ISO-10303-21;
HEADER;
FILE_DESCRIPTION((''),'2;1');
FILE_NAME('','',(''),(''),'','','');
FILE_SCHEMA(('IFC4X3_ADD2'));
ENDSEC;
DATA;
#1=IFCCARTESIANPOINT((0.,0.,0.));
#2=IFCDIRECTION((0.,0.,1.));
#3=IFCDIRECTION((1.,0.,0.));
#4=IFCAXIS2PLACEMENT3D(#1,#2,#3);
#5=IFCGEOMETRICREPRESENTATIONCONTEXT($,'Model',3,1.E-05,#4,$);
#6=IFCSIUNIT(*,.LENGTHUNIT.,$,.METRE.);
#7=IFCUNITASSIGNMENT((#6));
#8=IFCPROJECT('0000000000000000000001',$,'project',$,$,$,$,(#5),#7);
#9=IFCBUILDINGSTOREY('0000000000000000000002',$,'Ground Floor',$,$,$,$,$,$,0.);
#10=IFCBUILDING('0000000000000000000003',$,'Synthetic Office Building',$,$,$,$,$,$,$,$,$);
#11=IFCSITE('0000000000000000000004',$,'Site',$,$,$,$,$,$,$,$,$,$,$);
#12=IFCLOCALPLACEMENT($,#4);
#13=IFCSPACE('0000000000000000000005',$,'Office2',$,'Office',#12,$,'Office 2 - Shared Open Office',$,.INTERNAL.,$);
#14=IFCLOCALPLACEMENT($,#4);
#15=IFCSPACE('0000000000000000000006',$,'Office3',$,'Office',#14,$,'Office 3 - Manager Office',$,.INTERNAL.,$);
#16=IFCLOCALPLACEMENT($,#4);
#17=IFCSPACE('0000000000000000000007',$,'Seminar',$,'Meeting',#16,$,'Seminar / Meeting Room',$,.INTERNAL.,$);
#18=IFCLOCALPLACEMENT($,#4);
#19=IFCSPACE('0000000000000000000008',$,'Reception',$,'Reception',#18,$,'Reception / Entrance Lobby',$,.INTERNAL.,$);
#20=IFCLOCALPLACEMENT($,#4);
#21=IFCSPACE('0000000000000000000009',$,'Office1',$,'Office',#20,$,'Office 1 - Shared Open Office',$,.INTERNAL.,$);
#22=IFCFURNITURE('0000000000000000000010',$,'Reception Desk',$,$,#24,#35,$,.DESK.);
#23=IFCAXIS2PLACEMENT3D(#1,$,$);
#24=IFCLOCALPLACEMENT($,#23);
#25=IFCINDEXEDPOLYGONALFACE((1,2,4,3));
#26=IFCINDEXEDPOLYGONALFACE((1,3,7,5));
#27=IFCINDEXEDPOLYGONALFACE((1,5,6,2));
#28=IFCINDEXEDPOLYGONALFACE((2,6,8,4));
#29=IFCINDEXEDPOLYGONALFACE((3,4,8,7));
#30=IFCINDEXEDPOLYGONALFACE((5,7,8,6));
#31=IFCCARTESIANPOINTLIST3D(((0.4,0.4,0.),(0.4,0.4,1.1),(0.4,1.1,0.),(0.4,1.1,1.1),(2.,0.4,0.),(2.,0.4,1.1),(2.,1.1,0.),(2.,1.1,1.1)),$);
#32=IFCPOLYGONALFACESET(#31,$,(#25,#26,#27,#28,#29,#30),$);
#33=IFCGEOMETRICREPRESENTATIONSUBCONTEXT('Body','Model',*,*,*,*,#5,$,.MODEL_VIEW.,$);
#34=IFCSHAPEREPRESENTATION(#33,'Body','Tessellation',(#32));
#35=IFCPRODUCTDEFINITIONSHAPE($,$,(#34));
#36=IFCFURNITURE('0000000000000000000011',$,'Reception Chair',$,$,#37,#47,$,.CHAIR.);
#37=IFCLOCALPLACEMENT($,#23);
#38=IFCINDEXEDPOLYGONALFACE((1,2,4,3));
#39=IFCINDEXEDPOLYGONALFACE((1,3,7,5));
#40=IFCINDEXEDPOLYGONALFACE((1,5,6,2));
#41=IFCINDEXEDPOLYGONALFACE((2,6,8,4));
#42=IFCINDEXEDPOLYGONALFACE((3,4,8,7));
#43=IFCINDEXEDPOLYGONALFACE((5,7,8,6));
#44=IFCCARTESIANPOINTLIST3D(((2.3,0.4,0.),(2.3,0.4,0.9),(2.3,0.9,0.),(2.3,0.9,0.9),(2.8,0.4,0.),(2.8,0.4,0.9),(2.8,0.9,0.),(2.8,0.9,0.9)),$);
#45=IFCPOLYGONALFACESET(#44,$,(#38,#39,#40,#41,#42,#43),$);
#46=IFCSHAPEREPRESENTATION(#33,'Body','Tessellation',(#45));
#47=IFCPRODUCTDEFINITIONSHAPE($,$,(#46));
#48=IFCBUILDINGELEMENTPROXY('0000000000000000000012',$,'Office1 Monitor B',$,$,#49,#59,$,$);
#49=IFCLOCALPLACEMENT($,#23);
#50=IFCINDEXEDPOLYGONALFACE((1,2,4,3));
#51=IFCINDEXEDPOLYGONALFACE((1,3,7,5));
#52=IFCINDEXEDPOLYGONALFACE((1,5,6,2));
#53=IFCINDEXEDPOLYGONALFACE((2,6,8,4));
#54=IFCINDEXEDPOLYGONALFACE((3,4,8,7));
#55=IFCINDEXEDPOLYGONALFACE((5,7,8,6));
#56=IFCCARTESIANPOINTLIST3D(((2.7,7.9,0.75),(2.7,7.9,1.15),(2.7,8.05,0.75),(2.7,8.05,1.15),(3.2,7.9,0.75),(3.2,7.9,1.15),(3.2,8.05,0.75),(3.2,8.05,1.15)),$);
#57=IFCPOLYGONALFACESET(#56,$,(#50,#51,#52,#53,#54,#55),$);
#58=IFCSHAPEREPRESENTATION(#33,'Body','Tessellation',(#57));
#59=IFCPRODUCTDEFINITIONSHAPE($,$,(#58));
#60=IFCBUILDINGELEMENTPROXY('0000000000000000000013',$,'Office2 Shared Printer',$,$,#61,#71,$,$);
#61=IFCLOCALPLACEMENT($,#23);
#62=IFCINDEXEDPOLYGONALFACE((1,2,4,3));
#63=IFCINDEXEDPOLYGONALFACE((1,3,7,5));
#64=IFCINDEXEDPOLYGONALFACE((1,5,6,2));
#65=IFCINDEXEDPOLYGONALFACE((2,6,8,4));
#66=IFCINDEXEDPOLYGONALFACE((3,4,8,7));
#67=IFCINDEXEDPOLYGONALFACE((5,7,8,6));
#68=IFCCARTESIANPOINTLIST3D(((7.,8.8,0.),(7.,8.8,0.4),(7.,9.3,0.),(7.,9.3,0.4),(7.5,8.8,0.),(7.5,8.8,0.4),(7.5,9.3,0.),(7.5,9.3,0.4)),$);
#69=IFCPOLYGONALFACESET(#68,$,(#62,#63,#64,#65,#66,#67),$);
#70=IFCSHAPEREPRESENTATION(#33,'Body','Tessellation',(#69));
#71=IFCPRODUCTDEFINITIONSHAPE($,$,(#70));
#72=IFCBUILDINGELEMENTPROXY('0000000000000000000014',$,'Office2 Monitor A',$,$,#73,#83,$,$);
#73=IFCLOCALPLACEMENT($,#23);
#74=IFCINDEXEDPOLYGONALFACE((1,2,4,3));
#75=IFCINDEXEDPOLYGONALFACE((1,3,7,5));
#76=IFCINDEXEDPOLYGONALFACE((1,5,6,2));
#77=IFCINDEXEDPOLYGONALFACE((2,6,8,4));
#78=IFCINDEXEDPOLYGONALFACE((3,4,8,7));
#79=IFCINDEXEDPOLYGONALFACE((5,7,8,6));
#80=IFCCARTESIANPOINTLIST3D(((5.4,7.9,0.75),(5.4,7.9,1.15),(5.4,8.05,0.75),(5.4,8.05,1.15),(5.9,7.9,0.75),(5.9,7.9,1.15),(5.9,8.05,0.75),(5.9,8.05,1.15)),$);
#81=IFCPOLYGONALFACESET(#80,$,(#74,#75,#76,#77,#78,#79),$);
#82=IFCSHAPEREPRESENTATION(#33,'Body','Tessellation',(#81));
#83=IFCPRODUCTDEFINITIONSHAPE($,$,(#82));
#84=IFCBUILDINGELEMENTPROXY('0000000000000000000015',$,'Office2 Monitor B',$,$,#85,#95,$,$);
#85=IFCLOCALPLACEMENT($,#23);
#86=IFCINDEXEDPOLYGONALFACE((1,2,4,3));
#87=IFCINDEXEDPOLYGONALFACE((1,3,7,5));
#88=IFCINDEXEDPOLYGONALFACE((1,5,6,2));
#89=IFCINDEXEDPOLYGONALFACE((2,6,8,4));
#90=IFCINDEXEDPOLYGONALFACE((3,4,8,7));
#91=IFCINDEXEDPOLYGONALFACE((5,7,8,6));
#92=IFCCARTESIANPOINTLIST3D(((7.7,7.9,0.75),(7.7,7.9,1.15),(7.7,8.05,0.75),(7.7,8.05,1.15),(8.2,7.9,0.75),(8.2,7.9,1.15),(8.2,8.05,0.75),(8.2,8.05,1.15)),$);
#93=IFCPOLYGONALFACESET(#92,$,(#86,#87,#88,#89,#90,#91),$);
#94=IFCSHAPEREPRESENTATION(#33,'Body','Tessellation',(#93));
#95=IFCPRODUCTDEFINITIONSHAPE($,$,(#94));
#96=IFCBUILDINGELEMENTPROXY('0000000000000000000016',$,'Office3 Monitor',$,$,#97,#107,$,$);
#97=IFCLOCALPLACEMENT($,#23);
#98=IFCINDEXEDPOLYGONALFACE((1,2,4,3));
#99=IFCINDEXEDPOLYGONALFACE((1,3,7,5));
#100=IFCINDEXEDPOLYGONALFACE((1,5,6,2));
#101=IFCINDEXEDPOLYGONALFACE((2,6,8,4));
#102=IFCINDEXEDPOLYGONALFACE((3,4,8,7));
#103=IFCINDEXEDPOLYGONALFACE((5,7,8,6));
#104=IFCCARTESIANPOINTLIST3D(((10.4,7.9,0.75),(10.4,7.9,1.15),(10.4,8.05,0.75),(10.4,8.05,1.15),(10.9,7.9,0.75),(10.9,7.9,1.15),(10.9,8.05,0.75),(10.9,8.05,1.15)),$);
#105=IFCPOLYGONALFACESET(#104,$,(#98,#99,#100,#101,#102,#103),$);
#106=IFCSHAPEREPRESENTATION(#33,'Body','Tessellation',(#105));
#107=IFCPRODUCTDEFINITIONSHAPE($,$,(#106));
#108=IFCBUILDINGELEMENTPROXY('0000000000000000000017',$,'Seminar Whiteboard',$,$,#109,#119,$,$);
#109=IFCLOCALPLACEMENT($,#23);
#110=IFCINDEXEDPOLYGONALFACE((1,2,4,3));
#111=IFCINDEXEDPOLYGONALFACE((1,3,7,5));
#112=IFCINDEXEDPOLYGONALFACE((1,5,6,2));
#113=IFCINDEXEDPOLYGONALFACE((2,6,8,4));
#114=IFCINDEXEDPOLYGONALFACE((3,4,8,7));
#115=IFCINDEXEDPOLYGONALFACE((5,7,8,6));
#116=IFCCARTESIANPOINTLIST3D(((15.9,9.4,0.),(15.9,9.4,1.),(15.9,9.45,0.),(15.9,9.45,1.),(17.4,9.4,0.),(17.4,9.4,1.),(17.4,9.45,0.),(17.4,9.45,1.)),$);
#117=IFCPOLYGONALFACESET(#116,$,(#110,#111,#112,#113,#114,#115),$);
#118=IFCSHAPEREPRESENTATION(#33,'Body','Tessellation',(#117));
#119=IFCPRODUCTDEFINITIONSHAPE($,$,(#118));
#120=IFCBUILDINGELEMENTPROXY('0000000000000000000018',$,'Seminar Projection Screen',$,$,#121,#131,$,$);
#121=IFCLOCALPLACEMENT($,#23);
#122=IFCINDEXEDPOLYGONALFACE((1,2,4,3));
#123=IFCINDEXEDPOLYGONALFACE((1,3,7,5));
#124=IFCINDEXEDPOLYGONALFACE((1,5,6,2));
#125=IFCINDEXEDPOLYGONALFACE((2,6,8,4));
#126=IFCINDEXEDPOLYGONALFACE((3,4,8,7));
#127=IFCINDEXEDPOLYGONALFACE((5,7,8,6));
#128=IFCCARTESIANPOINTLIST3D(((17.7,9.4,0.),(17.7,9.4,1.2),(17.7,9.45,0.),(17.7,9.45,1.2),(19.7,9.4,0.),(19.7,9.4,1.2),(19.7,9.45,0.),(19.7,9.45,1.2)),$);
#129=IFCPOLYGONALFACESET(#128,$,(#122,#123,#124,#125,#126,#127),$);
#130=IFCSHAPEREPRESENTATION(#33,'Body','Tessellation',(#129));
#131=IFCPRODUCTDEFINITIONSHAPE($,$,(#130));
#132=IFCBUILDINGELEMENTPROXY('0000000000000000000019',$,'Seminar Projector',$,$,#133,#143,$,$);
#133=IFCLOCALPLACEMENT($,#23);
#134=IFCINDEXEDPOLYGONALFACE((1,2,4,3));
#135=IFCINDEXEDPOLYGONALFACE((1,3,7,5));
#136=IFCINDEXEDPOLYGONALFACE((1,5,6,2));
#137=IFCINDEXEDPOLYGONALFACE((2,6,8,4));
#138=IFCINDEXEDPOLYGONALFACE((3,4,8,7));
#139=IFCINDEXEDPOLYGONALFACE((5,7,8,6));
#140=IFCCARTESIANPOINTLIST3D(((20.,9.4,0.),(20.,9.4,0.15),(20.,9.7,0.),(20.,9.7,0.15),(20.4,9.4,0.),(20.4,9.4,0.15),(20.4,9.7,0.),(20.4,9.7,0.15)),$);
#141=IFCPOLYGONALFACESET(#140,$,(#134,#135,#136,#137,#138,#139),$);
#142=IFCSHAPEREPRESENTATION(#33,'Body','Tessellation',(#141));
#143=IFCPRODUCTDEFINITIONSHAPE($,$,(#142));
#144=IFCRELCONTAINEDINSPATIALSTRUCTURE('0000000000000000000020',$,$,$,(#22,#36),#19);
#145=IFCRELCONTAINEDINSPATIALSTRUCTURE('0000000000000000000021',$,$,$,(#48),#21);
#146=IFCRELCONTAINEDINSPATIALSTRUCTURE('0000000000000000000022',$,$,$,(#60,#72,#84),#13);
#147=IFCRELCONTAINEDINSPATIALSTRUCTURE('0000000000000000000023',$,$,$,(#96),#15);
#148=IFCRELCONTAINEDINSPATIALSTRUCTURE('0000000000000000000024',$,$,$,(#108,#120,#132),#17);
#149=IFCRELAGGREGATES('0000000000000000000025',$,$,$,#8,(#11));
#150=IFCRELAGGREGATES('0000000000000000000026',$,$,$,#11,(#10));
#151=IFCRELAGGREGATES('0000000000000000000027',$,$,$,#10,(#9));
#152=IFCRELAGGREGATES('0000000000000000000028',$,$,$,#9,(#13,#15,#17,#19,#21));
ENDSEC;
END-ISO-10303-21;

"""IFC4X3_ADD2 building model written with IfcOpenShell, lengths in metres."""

from ifc_helpers import new_model, si_unit, frame, origin_with_axes, place, context, subcontext, project, spatial, polyline, outline, extrude, element, save


model = new_model("IFC4X3_ADD2")

# Units and contexts
model_context = context("Model", 3, precision=1e-05, world=origin_with_axes())
body_context = subcontext(model_context, "Body", "Model", "MODEL_VIEW")
ifc_project = project(units=[si_unit("LENGTHUNIT", "METRE")], contexts=[model_context])

# Site, building, storey, space
site = spatial("IfcSite", under=ifc_project, Name="Site")
building = spatial("IfcBuilding", under=site, Name="Synthetic Office Building")
storey = spatial("IfcBuildingStorey", under=building, Name="Ground Floor", Elevation=0.0)
space_1_placement = place(None, origin_with_axes())
space_1 = spatial("IfcSpace", under=storey, at=space_1_placement, Name="Office2", ObjectType="Office", LongName="Office 2 - Shared Open Office", PredefinedType="INTERNAL")

# Shared definitions
space_2_placement = place(None, origin_with_axes())
space_2 = spatial("IfcSpace", under=storey, at=space_2_placement, Name="Office3", ObjectType="Office", LongName="Office 3 - Manager Office", PredefinedType="INTERNAL")

# Shared definitions
space_3_placement = place(None, origin_with_axes())
space_3 = spatial("IfcSpace", under=storey, at=space_3_placement, Name="Seminar", ObjectType="Meeting", LongName="Seminar / Meeting Room", PredefinedType="INTERNAL")

# Shared definitions
space_4_placement = place(None, origin_with_axes())
space_4 = spatial("IfcSpace", under=storey, at=space_4_placement, Name="Reception", ObjectType="Reception", LongName="Reception / Entrance Lobby", PredefinedType="INTERNAL")

# Furniture
furniture_1_placement = place(space_4_placement, origin_with_axes())
element("IfcFurniture", 1, at=furniture_1_placement, inside=space_4, Name="Reception Desk", PredefinedType="DESK", context=body_context, shape_type="SweptSolid", body=[
    extrude(outline(polyline([(0.4, 0.4), (2.0, 0.4), (2.0, 1.1), (0.4, 1.1), (0.4, 0.4)])), origin_with_axes(), (0.0, 0.0, 1.0), 1.1),
])
furniture_2_placement = place(space_4_placement, origin_with_axes())
element("IfcFurniture", 2, at=furniture_2_placement, inside=space_4, Name="Reception Chair", PredefinedType="CHAIR", context=body_context, shape_type="SweptSolid", body=[
    extrude(outline(polyline([(2.3, 0.4), (2.8, 0.4), (2.8, 0.9), (2.3, 0.9), (2.3, 0.4)])), origin_with_axes(), (0.0, 0.0, 1.0), 0.9),
])

# Shared definitions
space_5_placement = place(None, origin_with_axes())
space_5 = spatial("IfcSpace", under=storey, at=space_5_placement, Name="Office1", ObjectType="Office", LongName="Office 1 - Shared Open Office", PredefinedType="INTERNAL")

# Building element proxies
proxy_1_placement = place(space_5_placement, origin_with_axes())
element("IfcBuildingElementProxy", 3, at=proxy_1_placement, inside=space_5, Name="Office1 Monitor B", context=body_context, shape_type="SweptSolid", body=[
    extrude(outline(polyline([(2.7, 7.9), (3.2, 7.9), (3.2, 8.05), (2.7, 8.05), (2.7, 7.9)])), frame((0.0, 0.0, 0.75), z_axis=(0.0, 0.0, 1.0), x_axis=(1.0, 0.0, 0.0)), (0.0, 0.0, 1.0), 0.4),
])
proxy_2_placement = place(space_1_placement, origin_with_axes())
element("IfcBuildingElementProxy", 4, at=proxy_2_placement, inside=space_1, Name="Office2 Shared Printer", context=body_context, shape_type="SweptSolid", body=[
    extrude(outline(polyline([(7.0, 8.8), (7.5, 8.8), (7.5, 9.3), (7.0, 9.3), (7.0, 8.8)])), origin_with_axes(), (0.0, 0.0, 1.0), 0.4),
])
proxy_3_placement = place(space_1_placement, origin_with_axes())
element("IfcBuildingElementProxy", 5, at=proxy_3_placement, inside=space_1, Name="Office2 Monitor A", context=body_context, shape_type="SweptSolid", body=[
    extrude(outline(polyline([(5.4, 7.9), (5.9, 7.9), (5.9, 8.05), (5.4, 8.05), (5.4, 7.9)])), frame((0.0, 0.0, 0.75), z_axis=(0.0, 0.0, 1.0), x_axis=(1.0, 0.0, 0.0)), (0.0, 0.0, 1.0), 0.4),
])
proxy_4_placement = place(space_1_placement, origin_with_axes())
element("IfcBuildingElementProxy", 6, at=proxy_4_placement, inside=space_1, Name="Office2 Monitor B", context=body_context, shape_type="SweptSolid", body=[
    extrude(outline(polyline([(7.7, 7.9), (8.2, 7.9), (8.2, 8.05), (7.7, 8.05), (7.7, 7.9)])), frame((0.0, 0.0, 0.75), z_axis=(0.0, 0.0, 1.0), x_axis=(1.0, 0.0, 0.0)), (0.0, 0.0, 1.0), 0.4),
])
proxy_5_placement = place(space_2_placement, origin_with_axes())
element("IfcBuildingElementProxy", 7, at=proxy_5_placement, inside=space_2, Name="Office3 Monitor", context=body_context, shape_type="SweptSolid", body=[
    extrude(outline(polyline([(10.4, 7.9), (10.9, 7.9), (10.9, 8.05), (10.4, 8.05), (10.4, 7.9)])), frame((0.0, 0.0, 0.75), z_axis=(0.0, 0.0, 1.0), x_axis=(1.0, 0.0, 0.0)), (0.0, 0.0, 1.0), 0.4),
])
proxy_6_placement = place(space_3_placement, origin_with_axes())
element("IfcBuildingElementProxy", 8, at=proxy_6_placement, inside=space_3, Name="Seminar Whiteboard", context=body_context, shape_type="SweptSolid", body=[
    extrude(outline(polyline([(15.9, 9.4), (17.4, 9.4), (17.4, 9.45), (15.9, 9.45), (15.9, 9.4)])), origin_with_axes(), (0.0, 0.0, 1.0), 1.0),
])
proxy_7_placement = place(space_3_placement, origin_with_axes())
element("IfcBuildingElementProxy", 9, at=proxy_7_placement, inside=space_3, Name="Seminar Projection Screen", context=body_context, shape_type="SweptSolid", body=[
    extrude(outline(polyline([(17.7, 9.4), (19.7, 9.4), (19.7, 9.45), (17.7, 9.45), (17.7, 9.4)])), origin_with_axes(), (0.0, 0.0, 1.0), 1.2),
])
proxy_8_placement = place(space_3_placement, origin_with_axes())
element("IfcBuildingElementProxy", 10, at=proxy_8_placement, inside=space_3, Name="Seminar Projector", context=body_context, shape_type="SweptSolid", body=[
    extrude(outline(polyline([(20.0, 9.4), (20.4, 9.4), (20.4, 9.7), (20.0, 9.7), (20.0, 9.4)])), origin_with_axes(), (0.0, 0.0, 1.0), 0.15),
])

save(model, "model.ifc")
